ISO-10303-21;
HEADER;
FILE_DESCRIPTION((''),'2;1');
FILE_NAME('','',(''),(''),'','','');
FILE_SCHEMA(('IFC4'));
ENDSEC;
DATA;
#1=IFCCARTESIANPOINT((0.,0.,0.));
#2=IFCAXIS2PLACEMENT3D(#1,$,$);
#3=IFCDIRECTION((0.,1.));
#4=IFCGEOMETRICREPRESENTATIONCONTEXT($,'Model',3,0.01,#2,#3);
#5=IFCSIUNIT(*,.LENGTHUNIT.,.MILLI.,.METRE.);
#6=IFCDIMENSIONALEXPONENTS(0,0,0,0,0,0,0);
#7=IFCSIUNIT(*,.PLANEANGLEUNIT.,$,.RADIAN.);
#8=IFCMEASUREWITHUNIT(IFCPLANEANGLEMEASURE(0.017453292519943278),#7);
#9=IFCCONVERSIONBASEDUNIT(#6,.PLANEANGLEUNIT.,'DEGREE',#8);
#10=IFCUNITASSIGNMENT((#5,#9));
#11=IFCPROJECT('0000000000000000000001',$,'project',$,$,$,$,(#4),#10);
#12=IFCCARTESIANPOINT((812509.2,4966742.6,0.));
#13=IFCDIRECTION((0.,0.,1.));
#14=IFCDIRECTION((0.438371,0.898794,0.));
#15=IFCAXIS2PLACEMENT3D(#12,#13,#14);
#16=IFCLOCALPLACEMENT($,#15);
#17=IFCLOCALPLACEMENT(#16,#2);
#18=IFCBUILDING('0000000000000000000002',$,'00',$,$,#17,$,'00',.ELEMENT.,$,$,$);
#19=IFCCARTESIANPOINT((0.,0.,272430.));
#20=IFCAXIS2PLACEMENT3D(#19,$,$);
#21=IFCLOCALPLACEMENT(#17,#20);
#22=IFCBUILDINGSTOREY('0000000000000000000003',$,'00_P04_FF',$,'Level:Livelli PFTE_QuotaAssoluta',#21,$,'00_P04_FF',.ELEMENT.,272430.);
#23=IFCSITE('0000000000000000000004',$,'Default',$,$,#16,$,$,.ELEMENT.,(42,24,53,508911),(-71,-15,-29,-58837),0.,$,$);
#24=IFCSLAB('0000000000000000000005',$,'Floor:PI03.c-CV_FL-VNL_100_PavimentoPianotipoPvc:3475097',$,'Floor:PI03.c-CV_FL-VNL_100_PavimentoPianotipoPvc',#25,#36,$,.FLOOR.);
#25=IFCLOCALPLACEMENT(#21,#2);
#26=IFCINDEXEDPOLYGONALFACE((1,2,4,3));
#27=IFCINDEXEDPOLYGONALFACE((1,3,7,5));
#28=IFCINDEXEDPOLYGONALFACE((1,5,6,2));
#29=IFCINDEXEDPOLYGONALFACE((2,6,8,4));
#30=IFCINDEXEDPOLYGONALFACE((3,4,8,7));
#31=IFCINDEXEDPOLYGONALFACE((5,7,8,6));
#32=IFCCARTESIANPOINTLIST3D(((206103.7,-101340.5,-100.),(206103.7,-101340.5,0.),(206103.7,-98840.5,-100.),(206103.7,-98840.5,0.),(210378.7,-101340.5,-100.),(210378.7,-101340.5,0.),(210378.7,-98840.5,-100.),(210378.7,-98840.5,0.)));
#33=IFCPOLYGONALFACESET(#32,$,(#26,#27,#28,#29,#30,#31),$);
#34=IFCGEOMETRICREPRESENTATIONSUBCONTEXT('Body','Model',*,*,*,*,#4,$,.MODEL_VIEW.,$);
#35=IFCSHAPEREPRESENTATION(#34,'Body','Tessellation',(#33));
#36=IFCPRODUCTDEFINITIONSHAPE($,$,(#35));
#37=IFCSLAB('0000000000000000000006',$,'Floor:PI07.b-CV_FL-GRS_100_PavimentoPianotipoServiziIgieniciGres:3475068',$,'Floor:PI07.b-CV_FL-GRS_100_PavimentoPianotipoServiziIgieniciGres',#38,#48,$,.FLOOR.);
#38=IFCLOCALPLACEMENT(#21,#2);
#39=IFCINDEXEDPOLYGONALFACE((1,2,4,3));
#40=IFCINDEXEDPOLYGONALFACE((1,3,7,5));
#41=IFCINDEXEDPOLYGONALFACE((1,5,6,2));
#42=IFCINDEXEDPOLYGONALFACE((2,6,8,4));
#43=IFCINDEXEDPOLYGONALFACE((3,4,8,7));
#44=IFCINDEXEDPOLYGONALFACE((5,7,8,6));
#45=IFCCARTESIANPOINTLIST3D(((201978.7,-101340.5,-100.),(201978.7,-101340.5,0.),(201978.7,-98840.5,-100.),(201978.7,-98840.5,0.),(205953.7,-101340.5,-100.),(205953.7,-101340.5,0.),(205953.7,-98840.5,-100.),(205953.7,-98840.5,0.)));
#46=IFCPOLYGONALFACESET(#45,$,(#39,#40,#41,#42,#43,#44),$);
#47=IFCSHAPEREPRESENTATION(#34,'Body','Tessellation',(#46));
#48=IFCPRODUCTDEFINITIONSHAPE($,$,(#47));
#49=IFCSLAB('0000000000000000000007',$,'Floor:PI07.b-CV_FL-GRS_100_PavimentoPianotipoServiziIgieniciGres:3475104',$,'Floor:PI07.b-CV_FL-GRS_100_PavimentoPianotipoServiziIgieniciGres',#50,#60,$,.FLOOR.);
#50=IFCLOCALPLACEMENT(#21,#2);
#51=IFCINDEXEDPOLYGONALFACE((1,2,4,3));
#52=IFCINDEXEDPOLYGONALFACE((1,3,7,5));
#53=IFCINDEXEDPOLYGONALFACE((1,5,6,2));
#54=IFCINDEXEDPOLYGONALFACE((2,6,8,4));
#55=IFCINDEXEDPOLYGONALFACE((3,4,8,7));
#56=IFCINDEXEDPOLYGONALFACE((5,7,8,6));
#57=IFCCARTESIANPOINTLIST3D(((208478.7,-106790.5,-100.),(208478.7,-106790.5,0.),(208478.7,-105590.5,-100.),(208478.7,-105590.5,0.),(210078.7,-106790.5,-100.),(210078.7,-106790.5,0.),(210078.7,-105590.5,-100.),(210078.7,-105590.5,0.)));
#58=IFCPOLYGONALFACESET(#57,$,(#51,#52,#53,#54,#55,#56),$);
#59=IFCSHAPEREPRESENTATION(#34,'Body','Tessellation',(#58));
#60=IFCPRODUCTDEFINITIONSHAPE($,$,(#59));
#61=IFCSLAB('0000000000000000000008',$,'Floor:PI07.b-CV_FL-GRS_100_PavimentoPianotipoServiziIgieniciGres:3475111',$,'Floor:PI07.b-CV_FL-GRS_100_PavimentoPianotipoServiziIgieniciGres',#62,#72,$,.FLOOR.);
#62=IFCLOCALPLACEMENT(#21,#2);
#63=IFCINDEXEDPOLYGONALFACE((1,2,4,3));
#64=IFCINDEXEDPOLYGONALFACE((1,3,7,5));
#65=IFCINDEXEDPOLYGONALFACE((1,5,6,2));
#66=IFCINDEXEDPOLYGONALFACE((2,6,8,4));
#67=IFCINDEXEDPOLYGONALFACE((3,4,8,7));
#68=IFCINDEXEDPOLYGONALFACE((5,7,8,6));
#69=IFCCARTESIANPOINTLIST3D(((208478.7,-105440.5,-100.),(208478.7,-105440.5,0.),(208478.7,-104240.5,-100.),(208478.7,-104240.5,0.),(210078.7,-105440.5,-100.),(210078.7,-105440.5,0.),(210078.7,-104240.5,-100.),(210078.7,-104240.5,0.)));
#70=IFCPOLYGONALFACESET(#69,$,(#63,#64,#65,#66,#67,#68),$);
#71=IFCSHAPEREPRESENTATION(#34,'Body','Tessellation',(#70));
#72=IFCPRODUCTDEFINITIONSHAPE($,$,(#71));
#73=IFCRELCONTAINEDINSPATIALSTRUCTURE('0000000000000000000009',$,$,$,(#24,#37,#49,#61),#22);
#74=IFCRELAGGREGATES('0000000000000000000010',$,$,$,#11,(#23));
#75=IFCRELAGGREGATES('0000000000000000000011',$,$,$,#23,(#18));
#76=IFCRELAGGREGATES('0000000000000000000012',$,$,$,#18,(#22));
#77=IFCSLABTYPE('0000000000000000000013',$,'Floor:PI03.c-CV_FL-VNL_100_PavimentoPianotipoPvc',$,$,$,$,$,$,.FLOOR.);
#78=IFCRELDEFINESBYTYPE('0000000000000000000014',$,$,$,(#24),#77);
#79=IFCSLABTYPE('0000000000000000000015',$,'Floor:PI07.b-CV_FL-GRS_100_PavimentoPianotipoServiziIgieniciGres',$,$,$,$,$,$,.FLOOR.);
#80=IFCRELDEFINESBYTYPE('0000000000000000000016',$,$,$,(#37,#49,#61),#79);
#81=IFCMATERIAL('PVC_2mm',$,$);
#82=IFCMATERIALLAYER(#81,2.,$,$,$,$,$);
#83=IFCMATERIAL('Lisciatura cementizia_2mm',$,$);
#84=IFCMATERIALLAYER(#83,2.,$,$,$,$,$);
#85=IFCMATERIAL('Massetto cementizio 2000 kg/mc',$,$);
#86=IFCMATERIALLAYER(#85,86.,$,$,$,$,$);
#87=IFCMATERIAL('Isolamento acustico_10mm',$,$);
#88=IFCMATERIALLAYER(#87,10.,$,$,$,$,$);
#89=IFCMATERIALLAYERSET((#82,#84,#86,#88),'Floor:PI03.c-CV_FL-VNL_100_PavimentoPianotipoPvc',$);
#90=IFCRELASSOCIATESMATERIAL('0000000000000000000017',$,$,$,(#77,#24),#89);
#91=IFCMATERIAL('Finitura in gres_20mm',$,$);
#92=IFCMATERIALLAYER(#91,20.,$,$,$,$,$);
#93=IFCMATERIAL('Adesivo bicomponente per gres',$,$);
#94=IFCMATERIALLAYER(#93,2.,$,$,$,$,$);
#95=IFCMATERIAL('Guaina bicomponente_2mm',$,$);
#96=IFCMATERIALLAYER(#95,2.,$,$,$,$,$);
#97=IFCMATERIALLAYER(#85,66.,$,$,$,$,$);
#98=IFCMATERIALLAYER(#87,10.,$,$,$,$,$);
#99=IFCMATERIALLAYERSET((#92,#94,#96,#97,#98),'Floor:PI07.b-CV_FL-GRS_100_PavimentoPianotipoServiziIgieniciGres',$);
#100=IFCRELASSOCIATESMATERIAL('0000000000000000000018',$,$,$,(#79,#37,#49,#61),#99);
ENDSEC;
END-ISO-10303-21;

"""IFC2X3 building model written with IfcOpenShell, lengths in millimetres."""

from ifc_helpers import new_model, entity, si_unit, converted_unit, direction, frame, frame_2d, origin, place, context, subcontext, project, spatial, rectangle, extrude, material, layer, layer_set, layer_usage, type_object, element, save


model = new_model("IFC2X3")

# Units and contexts
model_context = context("Model", 3, precision=0.01, world=origin(), true_north=direction((0.0, 1.0)))
body_context = subcontext(model_context, "Body", "Model", "MODEL_VIEW")
ifc_project = project(units=[si_unit("LENGTHUNIT", "METRE", prefix="MILLI"), converted_unit("PLANEANGLEUNIT", "DEGREE", entity("IfcPlaneAngleMeasure", 0.017453292519943278), si_unit("PLANEANGLEUNIT", "RADIAN"), dimensions=[0, 0, 0, 0, 0, 0, 0])], contexts=[model_context])

# Site, building, storey
site_placement = place(None, frame((812509.2, 4966742.6, 0.0), z_axis=(0.0, 0.0, 1.0), x_axis=(0.438371, 0.898794, 0.0)))
site = spatial("IfcSite", under=ifc_project, at=site_placement, Name="Default", CompositionType="ELEMENT", RefLatitude=(42, 24, 53, 508911), RefLongitude=(-71, -15, -29, -58837), RefElevation=0.0)
building_placement = place(site_placement, origin())
building = spatial("IfcBuilding", under=site, at=building_placement, Name="00", LongName="00", CompositionType="ELEMENT")
storey_placement = place(building_placement, frame((0.0, 0.0, 272430.0)))
storey = spatial("IfcBuildingStorey", under=building, at=storey_placement, Name="00_P04_FF", ObjectType="Level:Livelli PFTE_QuotaAssoluta", LongName="00_P04_FF", CompositionType="ELEMENT", Elevation=272430.0)

# Slabs
ifc_material_1 = material(Name="PVC_2mm")
ifc_layer_1 = layer(ifc_material_1, 2.0)
ifc_material_2 = material(Name="Lisciatura cementizia_2mm")
ifc_layer_2 = layer(ifc_material_2, 2.0)
ifc_material_3 = material(Name="Massetto cementizio 2000 kg/mc")
ifc_layer_3 = layer(ifc_material_3, 86.0)
ifc_material_4 = material(Name="Isolamento acustico_10mm")
ifc_layer_4 = layer(ifc_material_4, 10.0)
ifc_layer_set_1 = layer_set([ifc_layer_1, ifc_layer_2, ifc_layer_3, ifc_layer_4], Name="Floor:PI03.c-CV_FL-VNL_100_PavimentoPianotipoPvc")
ifc_layer_usage_1 = layer_usage(ifc_layer_set_1, "AXIS3", "POSITIVE", 0.0)
slab_type_1 = type_object("IfcSlabType", Name="Floor:PI03.c-CV_FL-VNL_100_PavimentoPianotipoPvc", PredefinedType="FLOOR", material=ifc_layer_set_1)
slab_1_placement = place(storey_placement, origin())
element("IfcSlab", 1, at=slab_1_placement, inside=storey, type_object=slab_type_1, material=ifc_layer_usage_1, Name="Floor:PI03.c-CV_FL-VNL_100_PavimentoPianotipoPvc:3475097", ObjectType="Floor:PI03.c-CV_FL-VNL_100_PavimentoPianotipoPvc", PredefinedType="FLOOR", context=body_context, shape_type="SweptSolid", body=[
    extrude(rectangle(XDim=2500.0, YDim=4275.0, at=frame_2d((0.0, 0.0), x_axis=(1.0, 0.0))), frame((208241.2, -100090.5, 0.0), z_axis=(0.0, 0.0, -1.0), x_axis=(0.0, 1.0, 0.0)), (0.0, 0.0, 1.0), 100.0),
])
ifc_material_5 = material(Name="Finitura in gres_20mm")
ifc_layer_5 = layer(ifc_material_5, 20.0)
ifc_material_6 = material(Name="Adesivo bicomponente per gres")
ifc_layer_6 = layer(ifc_material_6, 2.0)
ifc_material_7 = material(Name="Guaina bicomponente_2mm")
ifc_layer_7 = layer(ifc_material_7, 2.0)
ifc_layer_8 = layer(ifc_material_3, 66.0)
ifc_layer_9 = layer(ifc_material_4, 10.0)
ifc_layer_set_2 = layer_set([ifc_layer_5, ifc_layer_6, ifc_layer_7, ifc_layer_8, ifc_layer_9], Name="Floor:PI07.b-CV_FL-GRS_100_PavimentoPianotipoServiziIgieniciGres")
ifc_layer_usage_2 = layer_usage(ifc_layer_set_2, "AXIS3", "POSITIVE", 0.0)
slab_type_2 = type_object("IfcSlabType", Name="Floor:PI07.b-CV_FL-GRS_100_PavimentoPianotipoServiziIgieniciGres", PredefinedType="FLOOR", material=ifc_layer_set_2)
slab_2_placement = place(storey_placement, origin())
element("IfcSlab", 2, at=slab_2_placement, inside=storey, type_object=slab_type_2, material=ifc_layer_usage_2, Name="Floor:PI07.b-CV_FL-GRS_100_PavimentoPianotipoServiziIgieniciGres:3475068", ObjectType="Floor:PI07.b-CV_FL-GRS_100_PavimentoPianotipoServiziIgieniciGres", PredefinedType="FLOOR", context=body_context, shape_type="SweptSolid", body=[
    extrude(rectangle(XDim=2500.0, YDim=3975.0, at=frame_2d((0.0, 0.0), x_axis=(1.0, 0.0))), frame((203966.2, -100090.5, 0.0), z_axis=(0.0, 0.0, -1.0), x_axis=(0.0, 1.0, 0.0)), (0.0, 0.0, 1.0), 100.0),
])
ifc_layer_usage_3 = layer_usage(ifc_layer_set_2, "AXIS3", "POSITIVE", 0.0)
slab_3_placement = place(storey_placement, origin())
element("IfcSlab", 3, at=slab_3_placement, inside=storey, type_object=slab_type_2, material=ifc_layer_usage_3, Name="Floor:PI07.b-CV_FL-GRS_100_PavimentoPianotipoServiziIgieniciGres:3475104", ObjectType="Floor:PI07.b-CV_FL-GRS_100_PavimentoPianotipoServiziIgieniciGres", PredefinedType="FLOOR", context=body_context, shape_type="SweptSolid", body=[
    extrude(rectangle(XDim=1200.0, YDim=1600.0, at=frame_2d((0.0, 0.0), x_axis=(1.0, 0.0))), frame((209278.7, -106190.5, 0.0), z_axis=(0.0, 0.0, -1.0), x_axis=(0.0, 1.0, 0.0)), (0.0, 0.0, 1.0), 100.0),
])
ifc_layer_usage_4 = layer_usage(ifc_layer_set_2, "AXIS3", "POSITIVE", 0.0)
slab_4_placement = place(storey_placement, origin())
element("IfcSlab", 4, at=slab_4_placement, inside=storey, type_object=slab_type_2, material=ifc_layer_usage_4, Name="Floor:PI07.b-CV_FL-GRS_100_PavimentoPianotipoServiziIgieniciGres:3475111", ObjectType="Floor:PI07.b-CV_FL-GRS_100_PavimentoPianotipoServiziIgieniciGres", PredefinedType="FLOOR", context=body_context, shape_type="SweptSolid", body=[
    extrude(rectangle(XDim=1200.0, YDim=1600.0, at=frame_2d((0.0, 0.0), x_axis=(1.0, 0.0))), frame((209278.7, -104840.5, 0.0), z_axis=(0.0, 0.0, -1.0), x_axis=(0.0, 1.0, 0.0)), (0.0, 0.0, 1.0), 100.0),
])

save(model, "model.ifc")
